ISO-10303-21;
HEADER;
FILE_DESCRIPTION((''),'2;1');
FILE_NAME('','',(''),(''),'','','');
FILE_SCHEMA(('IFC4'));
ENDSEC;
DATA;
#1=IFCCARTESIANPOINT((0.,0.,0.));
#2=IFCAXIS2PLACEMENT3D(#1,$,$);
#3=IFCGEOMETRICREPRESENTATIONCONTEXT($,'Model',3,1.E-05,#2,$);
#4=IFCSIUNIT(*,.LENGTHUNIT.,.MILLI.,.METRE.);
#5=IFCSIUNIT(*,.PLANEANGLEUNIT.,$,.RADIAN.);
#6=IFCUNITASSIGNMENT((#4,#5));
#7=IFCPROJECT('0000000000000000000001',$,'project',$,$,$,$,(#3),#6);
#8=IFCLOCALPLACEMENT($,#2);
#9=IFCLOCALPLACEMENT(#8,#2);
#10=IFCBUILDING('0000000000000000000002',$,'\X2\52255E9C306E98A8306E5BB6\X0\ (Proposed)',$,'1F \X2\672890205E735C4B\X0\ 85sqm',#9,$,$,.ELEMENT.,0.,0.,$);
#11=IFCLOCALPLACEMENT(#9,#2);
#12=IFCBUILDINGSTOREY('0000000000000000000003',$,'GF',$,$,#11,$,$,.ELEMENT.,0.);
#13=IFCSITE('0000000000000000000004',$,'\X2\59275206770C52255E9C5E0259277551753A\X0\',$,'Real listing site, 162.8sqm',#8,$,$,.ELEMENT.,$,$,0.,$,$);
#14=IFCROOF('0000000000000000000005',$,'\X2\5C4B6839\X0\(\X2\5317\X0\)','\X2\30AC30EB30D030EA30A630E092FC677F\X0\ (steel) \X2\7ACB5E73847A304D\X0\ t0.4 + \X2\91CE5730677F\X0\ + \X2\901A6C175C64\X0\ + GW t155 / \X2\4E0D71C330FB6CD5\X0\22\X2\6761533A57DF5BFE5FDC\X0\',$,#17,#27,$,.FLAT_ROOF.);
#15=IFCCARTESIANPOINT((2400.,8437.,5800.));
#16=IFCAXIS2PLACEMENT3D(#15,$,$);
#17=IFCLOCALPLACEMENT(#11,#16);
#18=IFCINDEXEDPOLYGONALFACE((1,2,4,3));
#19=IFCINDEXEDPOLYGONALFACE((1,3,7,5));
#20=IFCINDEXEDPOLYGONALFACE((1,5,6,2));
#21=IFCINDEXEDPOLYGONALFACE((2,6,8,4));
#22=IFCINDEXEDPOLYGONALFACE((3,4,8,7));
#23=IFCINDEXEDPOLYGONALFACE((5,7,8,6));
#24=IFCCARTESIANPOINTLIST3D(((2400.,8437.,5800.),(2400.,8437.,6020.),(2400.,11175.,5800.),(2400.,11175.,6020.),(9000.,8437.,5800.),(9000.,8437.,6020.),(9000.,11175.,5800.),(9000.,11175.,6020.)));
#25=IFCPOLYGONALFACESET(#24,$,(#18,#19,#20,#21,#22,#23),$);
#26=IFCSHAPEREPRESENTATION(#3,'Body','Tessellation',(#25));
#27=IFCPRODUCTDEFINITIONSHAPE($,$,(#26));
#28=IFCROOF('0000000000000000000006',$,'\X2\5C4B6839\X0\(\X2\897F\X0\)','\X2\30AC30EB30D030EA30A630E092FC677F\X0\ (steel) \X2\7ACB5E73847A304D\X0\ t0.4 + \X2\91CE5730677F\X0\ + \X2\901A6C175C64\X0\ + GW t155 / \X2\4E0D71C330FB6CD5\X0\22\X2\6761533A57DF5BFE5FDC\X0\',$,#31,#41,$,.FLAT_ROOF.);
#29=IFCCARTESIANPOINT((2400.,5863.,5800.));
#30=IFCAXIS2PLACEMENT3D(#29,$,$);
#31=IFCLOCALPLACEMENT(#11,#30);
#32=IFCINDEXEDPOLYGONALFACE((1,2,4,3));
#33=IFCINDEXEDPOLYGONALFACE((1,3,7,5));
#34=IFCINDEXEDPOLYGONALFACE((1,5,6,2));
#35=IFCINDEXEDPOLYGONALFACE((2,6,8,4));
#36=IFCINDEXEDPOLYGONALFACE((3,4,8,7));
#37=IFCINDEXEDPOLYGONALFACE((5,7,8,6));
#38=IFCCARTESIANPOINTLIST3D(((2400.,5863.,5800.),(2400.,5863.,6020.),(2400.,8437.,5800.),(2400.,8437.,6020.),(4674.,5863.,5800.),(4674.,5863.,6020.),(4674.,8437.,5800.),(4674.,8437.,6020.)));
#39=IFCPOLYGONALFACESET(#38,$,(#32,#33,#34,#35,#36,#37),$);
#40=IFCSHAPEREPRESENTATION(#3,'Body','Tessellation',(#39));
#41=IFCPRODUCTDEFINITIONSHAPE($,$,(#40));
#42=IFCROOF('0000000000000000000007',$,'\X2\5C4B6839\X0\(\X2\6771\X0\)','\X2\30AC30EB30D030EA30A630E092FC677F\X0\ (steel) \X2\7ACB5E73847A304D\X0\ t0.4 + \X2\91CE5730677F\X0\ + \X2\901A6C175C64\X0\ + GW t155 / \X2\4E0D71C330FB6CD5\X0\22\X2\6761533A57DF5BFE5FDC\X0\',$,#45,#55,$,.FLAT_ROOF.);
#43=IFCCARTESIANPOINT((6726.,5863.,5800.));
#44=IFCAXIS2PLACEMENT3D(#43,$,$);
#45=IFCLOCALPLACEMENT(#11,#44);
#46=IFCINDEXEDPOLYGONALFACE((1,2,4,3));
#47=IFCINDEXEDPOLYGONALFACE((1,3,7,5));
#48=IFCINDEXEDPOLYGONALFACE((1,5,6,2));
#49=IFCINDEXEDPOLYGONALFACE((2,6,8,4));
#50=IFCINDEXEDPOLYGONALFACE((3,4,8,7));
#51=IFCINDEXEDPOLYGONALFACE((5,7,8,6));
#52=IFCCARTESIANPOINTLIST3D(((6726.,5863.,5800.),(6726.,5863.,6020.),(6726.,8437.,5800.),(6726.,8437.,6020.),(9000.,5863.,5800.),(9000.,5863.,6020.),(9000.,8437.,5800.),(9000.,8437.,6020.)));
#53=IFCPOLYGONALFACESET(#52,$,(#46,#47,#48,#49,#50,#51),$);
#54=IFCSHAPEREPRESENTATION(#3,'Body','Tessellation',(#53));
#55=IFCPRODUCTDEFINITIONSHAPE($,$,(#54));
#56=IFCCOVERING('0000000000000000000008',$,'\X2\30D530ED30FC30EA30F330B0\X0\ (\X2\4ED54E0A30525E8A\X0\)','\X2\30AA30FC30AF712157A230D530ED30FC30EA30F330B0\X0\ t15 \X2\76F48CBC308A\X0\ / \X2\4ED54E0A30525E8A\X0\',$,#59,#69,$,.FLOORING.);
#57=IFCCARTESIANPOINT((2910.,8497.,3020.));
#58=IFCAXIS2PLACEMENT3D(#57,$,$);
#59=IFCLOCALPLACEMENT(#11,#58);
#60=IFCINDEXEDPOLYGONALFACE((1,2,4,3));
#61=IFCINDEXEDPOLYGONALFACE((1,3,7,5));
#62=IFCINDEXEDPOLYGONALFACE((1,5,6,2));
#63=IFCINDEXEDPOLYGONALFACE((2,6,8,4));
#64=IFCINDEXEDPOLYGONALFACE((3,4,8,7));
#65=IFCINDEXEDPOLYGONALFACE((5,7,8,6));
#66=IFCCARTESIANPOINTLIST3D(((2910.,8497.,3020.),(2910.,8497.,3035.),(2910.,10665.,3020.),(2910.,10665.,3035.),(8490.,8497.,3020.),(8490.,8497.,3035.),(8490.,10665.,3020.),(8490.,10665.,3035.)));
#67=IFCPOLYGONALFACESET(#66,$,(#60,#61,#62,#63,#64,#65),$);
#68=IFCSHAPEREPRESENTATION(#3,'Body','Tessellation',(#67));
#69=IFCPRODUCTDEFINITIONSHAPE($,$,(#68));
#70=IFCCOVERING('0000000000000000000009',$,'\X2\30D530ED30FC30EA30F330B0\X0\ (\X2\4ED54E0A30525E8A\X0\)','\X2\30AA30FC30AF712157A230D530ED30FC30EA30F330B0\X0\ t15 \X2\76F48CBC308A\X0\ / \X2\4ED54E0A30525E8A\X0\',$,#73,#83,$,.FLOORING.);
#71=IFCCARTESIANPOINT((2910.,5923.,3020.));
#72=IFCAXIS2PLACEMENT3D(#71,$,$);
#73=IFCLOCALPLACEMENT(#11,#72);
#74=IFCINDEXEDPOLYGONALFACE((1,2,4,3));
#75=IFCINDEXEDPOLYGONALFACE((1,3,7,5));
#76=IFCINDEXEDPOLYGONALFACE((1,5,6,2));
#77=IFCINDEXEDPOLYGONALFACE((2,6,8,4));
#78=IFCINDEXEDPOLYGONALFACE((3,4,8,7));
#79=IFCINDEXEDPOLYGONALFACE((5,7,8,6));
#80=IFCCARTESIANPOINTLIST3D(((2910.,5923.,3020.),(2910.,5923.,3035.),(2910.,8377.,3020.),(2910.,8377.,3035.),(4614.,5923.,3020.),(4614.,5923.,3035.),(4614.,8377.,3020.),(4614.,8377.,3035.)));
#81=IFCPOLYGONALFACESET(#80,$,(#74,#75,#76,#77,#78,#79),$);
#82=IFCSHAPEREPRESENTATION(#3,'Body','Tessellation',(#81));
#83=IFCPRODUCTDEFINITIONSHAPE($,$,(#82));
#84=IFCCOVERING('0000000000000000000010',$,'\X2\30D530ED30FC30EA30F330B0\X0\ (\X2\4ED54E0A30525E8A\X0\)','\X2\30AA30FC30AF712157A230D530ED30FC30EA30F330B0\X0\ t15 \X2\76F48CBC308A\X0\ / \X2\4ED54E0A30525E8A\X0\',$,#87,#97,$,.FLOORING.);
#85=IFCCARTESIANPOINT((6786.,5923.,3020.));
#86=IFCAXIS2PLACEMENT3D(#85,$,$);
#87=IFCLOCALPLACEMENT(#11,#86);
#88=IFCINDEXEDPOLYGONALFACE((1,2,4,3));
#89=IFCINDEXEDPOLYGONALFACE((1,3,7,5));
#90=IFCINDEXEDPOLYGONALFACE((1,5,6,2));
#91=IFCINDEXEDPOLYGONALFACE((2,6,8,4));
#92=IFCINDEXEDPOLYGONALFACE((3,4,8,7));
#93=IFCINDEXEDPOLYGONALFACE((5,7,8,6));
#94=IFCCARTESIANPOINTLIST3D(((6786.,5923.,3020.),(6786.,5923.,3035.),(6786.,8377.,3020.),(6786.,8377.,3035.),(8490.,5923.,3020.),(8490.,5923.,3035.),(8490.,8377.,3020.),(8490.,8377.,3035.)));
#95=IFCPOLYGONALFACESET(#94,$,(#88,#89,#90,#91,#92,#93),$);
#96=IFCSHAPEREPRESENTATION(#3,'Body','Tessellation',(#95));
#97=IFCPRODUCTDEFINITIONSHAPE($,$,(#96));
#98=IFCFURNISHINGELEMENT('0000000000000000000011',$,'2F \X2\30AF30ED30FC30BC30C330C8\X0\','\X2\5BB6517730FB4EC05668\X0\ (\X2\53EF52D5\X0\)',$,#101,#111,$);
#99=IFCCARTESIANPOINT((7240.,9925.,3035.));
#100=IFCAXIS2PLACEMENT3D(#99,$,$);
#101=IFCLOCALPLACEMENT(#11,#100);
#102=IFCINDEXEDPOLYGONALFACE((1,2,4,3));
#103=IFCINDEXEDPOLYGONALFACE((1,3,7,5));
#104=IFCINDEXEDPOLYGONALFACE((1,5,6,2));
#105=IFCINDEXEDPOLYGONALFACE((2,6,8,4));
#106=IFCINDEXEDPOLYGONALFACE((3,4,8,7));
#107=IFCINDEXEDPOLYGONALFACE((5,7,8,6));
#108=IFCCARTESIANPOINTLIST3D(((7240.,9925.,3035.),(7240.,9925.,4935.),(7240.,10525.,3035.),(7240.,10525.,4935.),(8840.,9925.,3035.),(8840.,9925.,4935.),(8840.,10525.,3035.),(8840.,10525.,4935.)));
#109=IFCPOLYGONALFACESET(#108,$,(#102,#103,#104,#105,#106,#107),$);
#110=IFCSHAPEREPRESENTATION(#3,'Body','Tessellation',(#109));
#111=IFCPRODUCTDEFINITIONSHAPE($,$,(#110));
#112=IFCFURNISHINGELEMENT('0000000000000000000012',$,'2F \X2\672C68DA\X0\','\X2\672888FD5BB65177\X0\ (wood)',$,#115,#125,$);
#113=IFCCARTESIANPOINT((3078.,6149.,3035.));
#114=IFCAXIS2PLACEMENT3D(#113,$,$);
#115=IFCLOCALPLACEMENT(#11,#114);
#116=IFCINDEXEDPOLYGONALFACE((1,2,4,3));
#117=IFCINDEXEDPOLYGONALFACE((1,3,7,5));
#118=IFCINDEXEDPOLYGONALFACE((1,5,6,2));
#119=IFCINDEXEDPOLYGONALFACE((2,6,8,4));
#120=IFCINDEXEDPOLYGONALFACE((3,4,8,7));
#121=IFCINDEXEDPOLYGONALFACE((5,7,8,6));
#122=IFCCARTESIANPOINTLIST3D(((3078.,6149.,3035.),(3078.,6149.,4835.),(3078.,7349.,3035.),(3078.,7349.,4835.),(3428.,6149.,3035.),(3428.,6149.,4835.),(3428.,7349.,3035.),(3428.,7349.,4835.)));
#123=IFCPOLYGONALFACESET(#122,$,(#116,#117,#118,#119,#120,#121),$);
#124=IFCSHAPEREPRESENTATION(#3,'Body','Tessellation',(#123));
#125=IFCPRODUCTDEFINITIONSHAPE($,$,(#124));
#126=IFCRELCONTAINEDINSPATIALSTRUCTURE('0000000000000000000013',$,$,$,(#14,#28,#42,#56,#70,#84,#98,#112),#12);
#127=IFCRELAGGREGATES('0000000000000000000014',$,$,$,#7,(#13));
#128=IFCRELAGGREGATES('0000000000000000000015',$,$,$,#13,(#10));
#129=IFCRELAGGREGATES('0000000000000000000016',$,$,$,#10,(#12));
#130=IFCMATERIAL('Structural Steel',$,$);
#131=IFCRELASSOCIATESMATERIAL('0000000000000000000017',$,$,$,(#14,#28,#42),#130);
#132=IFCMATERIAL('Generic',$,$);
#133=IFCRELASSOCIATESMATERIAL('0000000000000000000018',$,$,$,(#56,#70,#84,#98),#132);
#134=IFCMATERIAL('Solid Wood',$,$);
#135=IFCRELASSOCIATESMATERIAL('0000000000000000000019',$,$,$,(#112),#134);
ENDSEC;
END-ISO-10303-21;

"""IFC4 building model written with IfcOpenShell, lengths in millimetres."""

from ifc_helpers import new_model, si_unit, frame, frame_2d, origin, place, context, project, spatial, rectangle, extrude, material, element, save


model = new_model("IFC4")

# Units and contexts
model_context = context("Model", 3, precision=1e-05, world=origin())
ifc_project = project(units=[si_unit("LENGTHUNIT", "METRE", prefix="MILLI"), si_unit("PLANEANGLEUNIT", "RADIAN")], contexts=[model_context])

# Site, building, storey
site_placement = place(None, origin())
site = spatial("IfcSite", under=ifc_project, at=site_placement, Name="大分県別府市大畑町", ObjectType="Real listing site, 162.8sqm", CompositionType="ELEMENT", RefElevation=0.0)
building_placement = place(site_placement, origin())
building = spatial("IfcBuilding", under=site, at=building_placement, Name="別府の風の家 (Proposed)", ObjectType="1F 木造平屋 85sqm", CompositionType="ELEMENT", ElevationOfRefHeight=0.0, ElevationOfTerrain=0.0)
storey_placement = place(building_placement, origin())
storey = spatial("IfcBuildingStorey", under=building, at=storey_placement, Name="GF", CompositionType="ELEMENT", Elevation=0.0)

# Shared definitions
ifc_material_1 = material(Name="Solid Wood")

# Shared definitions
ifc_material_2 = material(Name="Generic")

# Roofs
ifc_material_3 = material(Name="Structural Steel")
for number, where, name in (
    (1, (2400.0, 8437.0, 5800.0), "屋根(北)"),
):
    element("IfcRoof", number, at=place(storey_placement, frame(where)), inside=storey, material=ifc_material_3, Name=name, Description="ガルバリウム鋼板 (steel) 立平葺き t0.4 + 野地板 + 通気層 + GW t155 / 不燃・法22条区域対応", PredefinedType="FLAT_ROOF", context=model_context, shape_type="SweptSolid", body=[
        extrude(rectangle(XDim=6600.0, YDim=2738.0, at=frame_2d((3300.0, 1369.0))), frame((2400.0, 8437.0, 5800.0)), (0.0, 0.0, 1.0), 220.0),
    ])
roof_1_placement = place(storey_placement, frame((2400.0, 5863.0, 5800.0)))
element("IfcRoof", 2, at=roof_1_placement, inside=storey, material=ifc_material_3, Name="屋根(西)", Description="ガルバリウム鋼板 (steel) 立平葺き t0.4 + 野地板 + 通気層 + GW t155 / 不燃・法22条区域対応", PredefinedType="FLAT_ROOF", context=model_context, shape_type="SweptSolid", body=[
    extrude(rectangle(XDim=2274.0, YDim=2574.0, at=frame_2d((1137.0, 1287.0))), frame((2400.0, 5863.0, 5800.0)), (0.0, 0.0, 1.0), 220.0),
])
roof_2_placement = place(storey_placement, frame((6726.0, 5863.0, 5800.0)))
element("IfcRoof", 3, at=roof_2_placement, inside=storey, material=ifc_material_3, Name="屋根(東)", Description="ガルバリウム鋼板 (steel) 立平葺き t0.4 + 野地板 + 通気層 + GW t155 / 不燃・法22条区域対応", PredefinedType="FLAT_ROOF", context=model_context, shape_type="SweptSolid", body=[
    extrude(rectangle(XDim=2274.0, YDim=2574.0, at=frame_2d((1137.0, 1287.0))), frame((6726.0, 5863.0, 5800.0)), (0.0, 0.0, 1.0), 220.0),
])

# Coverings
covering_1_placement = place(storey_placement, frame((2910.0, 8497.0, 3020.0)))
element("IfcCovering", 4, at=covering_1_placement, inside=storey, material=ifc_material_2, Name="フローリング (仕上げ床)", Description="オーク無垢フローリング t15 直貼り / 仕上げ床", PredefinedType="FLOORING", context=model_context, shape_type="SweptSolid", body=[
    extrude(rectangle(XDim=5580.0, YDim=2168.0, at=frame_2d((2790.0, 1084.0))), frame((2910.0, 8497.0, 3020.0)), (0.0, 0.0, 1.0), 15.0),
])
covering_2_placement = place(storey_placement, frame((2910.0, 5923.0, 3020.0)))
element("IfcCovering", 5, at=covering_2_placement, inside=storey, material=ifc_material_2, Name="フローリング (仕上げ床)", Description="オーク無垢フローリング t15 直貼り / 仕上げ床", PredefinedType="FLOORING", context=model_context, shape_type="SweptSolid", body=[
    extrude(rectangle(XDim=1704.0, YDim=2454.0, at=frame_2d((852.0, 1227.0))), frame((2910.0, 5923.0, 3020.0)), (0.0, 0.0, 1.0), 15.0),
])
covering_3_placement = place(storey_placement, frame((6786.0, 5923.0, 3020.0)))
element("IfcCovering", 6, at=covering_3_placement, inside=storey, material=ifc_material_2, Name="フローリング (仕上げ床)", Description="オーク無垢フローリング t15 直貼り / 仕上げ床", PredefinedType="FLOORING", context=model_context, shape_type="SweptSolid", body=[
    extrude(rectangle(XDim=1704.0, YDim=2454.0, at=frame_2d((852.0, 1227.0))), frame((6786.0, 5923.0, 3020.0)), (0.0, 0.0, 1.0), 15.0),
])

# Furnishing elements
furnishing_1_placement = place(storey_placement, frame((7240.0, 9925.0, 3035.0)))
element("IfcFurnishingElement", 7, at=furnishing_1_placement, inside=storey, material=ifc_material_2, Name="2F クローゼット", Description="家具・什器 (可動)", context=model_context, shape_type="SweptSolid", body=[
    extrude(rectangle(XDim=1600.0, YDim=600.0, at=frame_2d((800.0, 300.0))), frame((7240.0, 9925.0, 3035.0)), (0.0, 0.0, 1.0), 1900.0),
])
furnishing_2_placement = place(storey_placement, frame((3078.0, 6149.0, 3035.0)))
element("IfcFurnishingElement", 8, at=furnishing_2_placement, inside=storey, material=ifc_material_1, Name="2F 本棚", Description="木製家具 (wood)", context=model_context, shape_type="SweptSolid", body=[
    extrude(rectangle(XDim=350.0, YDim=1200.0, at=frame_2d((175.0, 600.0))), frame((3078.0, 6149.0, 3035.0)), (0.0, 0.0, 1.0), 1800.0),
])

save(model, "model.ifc")
